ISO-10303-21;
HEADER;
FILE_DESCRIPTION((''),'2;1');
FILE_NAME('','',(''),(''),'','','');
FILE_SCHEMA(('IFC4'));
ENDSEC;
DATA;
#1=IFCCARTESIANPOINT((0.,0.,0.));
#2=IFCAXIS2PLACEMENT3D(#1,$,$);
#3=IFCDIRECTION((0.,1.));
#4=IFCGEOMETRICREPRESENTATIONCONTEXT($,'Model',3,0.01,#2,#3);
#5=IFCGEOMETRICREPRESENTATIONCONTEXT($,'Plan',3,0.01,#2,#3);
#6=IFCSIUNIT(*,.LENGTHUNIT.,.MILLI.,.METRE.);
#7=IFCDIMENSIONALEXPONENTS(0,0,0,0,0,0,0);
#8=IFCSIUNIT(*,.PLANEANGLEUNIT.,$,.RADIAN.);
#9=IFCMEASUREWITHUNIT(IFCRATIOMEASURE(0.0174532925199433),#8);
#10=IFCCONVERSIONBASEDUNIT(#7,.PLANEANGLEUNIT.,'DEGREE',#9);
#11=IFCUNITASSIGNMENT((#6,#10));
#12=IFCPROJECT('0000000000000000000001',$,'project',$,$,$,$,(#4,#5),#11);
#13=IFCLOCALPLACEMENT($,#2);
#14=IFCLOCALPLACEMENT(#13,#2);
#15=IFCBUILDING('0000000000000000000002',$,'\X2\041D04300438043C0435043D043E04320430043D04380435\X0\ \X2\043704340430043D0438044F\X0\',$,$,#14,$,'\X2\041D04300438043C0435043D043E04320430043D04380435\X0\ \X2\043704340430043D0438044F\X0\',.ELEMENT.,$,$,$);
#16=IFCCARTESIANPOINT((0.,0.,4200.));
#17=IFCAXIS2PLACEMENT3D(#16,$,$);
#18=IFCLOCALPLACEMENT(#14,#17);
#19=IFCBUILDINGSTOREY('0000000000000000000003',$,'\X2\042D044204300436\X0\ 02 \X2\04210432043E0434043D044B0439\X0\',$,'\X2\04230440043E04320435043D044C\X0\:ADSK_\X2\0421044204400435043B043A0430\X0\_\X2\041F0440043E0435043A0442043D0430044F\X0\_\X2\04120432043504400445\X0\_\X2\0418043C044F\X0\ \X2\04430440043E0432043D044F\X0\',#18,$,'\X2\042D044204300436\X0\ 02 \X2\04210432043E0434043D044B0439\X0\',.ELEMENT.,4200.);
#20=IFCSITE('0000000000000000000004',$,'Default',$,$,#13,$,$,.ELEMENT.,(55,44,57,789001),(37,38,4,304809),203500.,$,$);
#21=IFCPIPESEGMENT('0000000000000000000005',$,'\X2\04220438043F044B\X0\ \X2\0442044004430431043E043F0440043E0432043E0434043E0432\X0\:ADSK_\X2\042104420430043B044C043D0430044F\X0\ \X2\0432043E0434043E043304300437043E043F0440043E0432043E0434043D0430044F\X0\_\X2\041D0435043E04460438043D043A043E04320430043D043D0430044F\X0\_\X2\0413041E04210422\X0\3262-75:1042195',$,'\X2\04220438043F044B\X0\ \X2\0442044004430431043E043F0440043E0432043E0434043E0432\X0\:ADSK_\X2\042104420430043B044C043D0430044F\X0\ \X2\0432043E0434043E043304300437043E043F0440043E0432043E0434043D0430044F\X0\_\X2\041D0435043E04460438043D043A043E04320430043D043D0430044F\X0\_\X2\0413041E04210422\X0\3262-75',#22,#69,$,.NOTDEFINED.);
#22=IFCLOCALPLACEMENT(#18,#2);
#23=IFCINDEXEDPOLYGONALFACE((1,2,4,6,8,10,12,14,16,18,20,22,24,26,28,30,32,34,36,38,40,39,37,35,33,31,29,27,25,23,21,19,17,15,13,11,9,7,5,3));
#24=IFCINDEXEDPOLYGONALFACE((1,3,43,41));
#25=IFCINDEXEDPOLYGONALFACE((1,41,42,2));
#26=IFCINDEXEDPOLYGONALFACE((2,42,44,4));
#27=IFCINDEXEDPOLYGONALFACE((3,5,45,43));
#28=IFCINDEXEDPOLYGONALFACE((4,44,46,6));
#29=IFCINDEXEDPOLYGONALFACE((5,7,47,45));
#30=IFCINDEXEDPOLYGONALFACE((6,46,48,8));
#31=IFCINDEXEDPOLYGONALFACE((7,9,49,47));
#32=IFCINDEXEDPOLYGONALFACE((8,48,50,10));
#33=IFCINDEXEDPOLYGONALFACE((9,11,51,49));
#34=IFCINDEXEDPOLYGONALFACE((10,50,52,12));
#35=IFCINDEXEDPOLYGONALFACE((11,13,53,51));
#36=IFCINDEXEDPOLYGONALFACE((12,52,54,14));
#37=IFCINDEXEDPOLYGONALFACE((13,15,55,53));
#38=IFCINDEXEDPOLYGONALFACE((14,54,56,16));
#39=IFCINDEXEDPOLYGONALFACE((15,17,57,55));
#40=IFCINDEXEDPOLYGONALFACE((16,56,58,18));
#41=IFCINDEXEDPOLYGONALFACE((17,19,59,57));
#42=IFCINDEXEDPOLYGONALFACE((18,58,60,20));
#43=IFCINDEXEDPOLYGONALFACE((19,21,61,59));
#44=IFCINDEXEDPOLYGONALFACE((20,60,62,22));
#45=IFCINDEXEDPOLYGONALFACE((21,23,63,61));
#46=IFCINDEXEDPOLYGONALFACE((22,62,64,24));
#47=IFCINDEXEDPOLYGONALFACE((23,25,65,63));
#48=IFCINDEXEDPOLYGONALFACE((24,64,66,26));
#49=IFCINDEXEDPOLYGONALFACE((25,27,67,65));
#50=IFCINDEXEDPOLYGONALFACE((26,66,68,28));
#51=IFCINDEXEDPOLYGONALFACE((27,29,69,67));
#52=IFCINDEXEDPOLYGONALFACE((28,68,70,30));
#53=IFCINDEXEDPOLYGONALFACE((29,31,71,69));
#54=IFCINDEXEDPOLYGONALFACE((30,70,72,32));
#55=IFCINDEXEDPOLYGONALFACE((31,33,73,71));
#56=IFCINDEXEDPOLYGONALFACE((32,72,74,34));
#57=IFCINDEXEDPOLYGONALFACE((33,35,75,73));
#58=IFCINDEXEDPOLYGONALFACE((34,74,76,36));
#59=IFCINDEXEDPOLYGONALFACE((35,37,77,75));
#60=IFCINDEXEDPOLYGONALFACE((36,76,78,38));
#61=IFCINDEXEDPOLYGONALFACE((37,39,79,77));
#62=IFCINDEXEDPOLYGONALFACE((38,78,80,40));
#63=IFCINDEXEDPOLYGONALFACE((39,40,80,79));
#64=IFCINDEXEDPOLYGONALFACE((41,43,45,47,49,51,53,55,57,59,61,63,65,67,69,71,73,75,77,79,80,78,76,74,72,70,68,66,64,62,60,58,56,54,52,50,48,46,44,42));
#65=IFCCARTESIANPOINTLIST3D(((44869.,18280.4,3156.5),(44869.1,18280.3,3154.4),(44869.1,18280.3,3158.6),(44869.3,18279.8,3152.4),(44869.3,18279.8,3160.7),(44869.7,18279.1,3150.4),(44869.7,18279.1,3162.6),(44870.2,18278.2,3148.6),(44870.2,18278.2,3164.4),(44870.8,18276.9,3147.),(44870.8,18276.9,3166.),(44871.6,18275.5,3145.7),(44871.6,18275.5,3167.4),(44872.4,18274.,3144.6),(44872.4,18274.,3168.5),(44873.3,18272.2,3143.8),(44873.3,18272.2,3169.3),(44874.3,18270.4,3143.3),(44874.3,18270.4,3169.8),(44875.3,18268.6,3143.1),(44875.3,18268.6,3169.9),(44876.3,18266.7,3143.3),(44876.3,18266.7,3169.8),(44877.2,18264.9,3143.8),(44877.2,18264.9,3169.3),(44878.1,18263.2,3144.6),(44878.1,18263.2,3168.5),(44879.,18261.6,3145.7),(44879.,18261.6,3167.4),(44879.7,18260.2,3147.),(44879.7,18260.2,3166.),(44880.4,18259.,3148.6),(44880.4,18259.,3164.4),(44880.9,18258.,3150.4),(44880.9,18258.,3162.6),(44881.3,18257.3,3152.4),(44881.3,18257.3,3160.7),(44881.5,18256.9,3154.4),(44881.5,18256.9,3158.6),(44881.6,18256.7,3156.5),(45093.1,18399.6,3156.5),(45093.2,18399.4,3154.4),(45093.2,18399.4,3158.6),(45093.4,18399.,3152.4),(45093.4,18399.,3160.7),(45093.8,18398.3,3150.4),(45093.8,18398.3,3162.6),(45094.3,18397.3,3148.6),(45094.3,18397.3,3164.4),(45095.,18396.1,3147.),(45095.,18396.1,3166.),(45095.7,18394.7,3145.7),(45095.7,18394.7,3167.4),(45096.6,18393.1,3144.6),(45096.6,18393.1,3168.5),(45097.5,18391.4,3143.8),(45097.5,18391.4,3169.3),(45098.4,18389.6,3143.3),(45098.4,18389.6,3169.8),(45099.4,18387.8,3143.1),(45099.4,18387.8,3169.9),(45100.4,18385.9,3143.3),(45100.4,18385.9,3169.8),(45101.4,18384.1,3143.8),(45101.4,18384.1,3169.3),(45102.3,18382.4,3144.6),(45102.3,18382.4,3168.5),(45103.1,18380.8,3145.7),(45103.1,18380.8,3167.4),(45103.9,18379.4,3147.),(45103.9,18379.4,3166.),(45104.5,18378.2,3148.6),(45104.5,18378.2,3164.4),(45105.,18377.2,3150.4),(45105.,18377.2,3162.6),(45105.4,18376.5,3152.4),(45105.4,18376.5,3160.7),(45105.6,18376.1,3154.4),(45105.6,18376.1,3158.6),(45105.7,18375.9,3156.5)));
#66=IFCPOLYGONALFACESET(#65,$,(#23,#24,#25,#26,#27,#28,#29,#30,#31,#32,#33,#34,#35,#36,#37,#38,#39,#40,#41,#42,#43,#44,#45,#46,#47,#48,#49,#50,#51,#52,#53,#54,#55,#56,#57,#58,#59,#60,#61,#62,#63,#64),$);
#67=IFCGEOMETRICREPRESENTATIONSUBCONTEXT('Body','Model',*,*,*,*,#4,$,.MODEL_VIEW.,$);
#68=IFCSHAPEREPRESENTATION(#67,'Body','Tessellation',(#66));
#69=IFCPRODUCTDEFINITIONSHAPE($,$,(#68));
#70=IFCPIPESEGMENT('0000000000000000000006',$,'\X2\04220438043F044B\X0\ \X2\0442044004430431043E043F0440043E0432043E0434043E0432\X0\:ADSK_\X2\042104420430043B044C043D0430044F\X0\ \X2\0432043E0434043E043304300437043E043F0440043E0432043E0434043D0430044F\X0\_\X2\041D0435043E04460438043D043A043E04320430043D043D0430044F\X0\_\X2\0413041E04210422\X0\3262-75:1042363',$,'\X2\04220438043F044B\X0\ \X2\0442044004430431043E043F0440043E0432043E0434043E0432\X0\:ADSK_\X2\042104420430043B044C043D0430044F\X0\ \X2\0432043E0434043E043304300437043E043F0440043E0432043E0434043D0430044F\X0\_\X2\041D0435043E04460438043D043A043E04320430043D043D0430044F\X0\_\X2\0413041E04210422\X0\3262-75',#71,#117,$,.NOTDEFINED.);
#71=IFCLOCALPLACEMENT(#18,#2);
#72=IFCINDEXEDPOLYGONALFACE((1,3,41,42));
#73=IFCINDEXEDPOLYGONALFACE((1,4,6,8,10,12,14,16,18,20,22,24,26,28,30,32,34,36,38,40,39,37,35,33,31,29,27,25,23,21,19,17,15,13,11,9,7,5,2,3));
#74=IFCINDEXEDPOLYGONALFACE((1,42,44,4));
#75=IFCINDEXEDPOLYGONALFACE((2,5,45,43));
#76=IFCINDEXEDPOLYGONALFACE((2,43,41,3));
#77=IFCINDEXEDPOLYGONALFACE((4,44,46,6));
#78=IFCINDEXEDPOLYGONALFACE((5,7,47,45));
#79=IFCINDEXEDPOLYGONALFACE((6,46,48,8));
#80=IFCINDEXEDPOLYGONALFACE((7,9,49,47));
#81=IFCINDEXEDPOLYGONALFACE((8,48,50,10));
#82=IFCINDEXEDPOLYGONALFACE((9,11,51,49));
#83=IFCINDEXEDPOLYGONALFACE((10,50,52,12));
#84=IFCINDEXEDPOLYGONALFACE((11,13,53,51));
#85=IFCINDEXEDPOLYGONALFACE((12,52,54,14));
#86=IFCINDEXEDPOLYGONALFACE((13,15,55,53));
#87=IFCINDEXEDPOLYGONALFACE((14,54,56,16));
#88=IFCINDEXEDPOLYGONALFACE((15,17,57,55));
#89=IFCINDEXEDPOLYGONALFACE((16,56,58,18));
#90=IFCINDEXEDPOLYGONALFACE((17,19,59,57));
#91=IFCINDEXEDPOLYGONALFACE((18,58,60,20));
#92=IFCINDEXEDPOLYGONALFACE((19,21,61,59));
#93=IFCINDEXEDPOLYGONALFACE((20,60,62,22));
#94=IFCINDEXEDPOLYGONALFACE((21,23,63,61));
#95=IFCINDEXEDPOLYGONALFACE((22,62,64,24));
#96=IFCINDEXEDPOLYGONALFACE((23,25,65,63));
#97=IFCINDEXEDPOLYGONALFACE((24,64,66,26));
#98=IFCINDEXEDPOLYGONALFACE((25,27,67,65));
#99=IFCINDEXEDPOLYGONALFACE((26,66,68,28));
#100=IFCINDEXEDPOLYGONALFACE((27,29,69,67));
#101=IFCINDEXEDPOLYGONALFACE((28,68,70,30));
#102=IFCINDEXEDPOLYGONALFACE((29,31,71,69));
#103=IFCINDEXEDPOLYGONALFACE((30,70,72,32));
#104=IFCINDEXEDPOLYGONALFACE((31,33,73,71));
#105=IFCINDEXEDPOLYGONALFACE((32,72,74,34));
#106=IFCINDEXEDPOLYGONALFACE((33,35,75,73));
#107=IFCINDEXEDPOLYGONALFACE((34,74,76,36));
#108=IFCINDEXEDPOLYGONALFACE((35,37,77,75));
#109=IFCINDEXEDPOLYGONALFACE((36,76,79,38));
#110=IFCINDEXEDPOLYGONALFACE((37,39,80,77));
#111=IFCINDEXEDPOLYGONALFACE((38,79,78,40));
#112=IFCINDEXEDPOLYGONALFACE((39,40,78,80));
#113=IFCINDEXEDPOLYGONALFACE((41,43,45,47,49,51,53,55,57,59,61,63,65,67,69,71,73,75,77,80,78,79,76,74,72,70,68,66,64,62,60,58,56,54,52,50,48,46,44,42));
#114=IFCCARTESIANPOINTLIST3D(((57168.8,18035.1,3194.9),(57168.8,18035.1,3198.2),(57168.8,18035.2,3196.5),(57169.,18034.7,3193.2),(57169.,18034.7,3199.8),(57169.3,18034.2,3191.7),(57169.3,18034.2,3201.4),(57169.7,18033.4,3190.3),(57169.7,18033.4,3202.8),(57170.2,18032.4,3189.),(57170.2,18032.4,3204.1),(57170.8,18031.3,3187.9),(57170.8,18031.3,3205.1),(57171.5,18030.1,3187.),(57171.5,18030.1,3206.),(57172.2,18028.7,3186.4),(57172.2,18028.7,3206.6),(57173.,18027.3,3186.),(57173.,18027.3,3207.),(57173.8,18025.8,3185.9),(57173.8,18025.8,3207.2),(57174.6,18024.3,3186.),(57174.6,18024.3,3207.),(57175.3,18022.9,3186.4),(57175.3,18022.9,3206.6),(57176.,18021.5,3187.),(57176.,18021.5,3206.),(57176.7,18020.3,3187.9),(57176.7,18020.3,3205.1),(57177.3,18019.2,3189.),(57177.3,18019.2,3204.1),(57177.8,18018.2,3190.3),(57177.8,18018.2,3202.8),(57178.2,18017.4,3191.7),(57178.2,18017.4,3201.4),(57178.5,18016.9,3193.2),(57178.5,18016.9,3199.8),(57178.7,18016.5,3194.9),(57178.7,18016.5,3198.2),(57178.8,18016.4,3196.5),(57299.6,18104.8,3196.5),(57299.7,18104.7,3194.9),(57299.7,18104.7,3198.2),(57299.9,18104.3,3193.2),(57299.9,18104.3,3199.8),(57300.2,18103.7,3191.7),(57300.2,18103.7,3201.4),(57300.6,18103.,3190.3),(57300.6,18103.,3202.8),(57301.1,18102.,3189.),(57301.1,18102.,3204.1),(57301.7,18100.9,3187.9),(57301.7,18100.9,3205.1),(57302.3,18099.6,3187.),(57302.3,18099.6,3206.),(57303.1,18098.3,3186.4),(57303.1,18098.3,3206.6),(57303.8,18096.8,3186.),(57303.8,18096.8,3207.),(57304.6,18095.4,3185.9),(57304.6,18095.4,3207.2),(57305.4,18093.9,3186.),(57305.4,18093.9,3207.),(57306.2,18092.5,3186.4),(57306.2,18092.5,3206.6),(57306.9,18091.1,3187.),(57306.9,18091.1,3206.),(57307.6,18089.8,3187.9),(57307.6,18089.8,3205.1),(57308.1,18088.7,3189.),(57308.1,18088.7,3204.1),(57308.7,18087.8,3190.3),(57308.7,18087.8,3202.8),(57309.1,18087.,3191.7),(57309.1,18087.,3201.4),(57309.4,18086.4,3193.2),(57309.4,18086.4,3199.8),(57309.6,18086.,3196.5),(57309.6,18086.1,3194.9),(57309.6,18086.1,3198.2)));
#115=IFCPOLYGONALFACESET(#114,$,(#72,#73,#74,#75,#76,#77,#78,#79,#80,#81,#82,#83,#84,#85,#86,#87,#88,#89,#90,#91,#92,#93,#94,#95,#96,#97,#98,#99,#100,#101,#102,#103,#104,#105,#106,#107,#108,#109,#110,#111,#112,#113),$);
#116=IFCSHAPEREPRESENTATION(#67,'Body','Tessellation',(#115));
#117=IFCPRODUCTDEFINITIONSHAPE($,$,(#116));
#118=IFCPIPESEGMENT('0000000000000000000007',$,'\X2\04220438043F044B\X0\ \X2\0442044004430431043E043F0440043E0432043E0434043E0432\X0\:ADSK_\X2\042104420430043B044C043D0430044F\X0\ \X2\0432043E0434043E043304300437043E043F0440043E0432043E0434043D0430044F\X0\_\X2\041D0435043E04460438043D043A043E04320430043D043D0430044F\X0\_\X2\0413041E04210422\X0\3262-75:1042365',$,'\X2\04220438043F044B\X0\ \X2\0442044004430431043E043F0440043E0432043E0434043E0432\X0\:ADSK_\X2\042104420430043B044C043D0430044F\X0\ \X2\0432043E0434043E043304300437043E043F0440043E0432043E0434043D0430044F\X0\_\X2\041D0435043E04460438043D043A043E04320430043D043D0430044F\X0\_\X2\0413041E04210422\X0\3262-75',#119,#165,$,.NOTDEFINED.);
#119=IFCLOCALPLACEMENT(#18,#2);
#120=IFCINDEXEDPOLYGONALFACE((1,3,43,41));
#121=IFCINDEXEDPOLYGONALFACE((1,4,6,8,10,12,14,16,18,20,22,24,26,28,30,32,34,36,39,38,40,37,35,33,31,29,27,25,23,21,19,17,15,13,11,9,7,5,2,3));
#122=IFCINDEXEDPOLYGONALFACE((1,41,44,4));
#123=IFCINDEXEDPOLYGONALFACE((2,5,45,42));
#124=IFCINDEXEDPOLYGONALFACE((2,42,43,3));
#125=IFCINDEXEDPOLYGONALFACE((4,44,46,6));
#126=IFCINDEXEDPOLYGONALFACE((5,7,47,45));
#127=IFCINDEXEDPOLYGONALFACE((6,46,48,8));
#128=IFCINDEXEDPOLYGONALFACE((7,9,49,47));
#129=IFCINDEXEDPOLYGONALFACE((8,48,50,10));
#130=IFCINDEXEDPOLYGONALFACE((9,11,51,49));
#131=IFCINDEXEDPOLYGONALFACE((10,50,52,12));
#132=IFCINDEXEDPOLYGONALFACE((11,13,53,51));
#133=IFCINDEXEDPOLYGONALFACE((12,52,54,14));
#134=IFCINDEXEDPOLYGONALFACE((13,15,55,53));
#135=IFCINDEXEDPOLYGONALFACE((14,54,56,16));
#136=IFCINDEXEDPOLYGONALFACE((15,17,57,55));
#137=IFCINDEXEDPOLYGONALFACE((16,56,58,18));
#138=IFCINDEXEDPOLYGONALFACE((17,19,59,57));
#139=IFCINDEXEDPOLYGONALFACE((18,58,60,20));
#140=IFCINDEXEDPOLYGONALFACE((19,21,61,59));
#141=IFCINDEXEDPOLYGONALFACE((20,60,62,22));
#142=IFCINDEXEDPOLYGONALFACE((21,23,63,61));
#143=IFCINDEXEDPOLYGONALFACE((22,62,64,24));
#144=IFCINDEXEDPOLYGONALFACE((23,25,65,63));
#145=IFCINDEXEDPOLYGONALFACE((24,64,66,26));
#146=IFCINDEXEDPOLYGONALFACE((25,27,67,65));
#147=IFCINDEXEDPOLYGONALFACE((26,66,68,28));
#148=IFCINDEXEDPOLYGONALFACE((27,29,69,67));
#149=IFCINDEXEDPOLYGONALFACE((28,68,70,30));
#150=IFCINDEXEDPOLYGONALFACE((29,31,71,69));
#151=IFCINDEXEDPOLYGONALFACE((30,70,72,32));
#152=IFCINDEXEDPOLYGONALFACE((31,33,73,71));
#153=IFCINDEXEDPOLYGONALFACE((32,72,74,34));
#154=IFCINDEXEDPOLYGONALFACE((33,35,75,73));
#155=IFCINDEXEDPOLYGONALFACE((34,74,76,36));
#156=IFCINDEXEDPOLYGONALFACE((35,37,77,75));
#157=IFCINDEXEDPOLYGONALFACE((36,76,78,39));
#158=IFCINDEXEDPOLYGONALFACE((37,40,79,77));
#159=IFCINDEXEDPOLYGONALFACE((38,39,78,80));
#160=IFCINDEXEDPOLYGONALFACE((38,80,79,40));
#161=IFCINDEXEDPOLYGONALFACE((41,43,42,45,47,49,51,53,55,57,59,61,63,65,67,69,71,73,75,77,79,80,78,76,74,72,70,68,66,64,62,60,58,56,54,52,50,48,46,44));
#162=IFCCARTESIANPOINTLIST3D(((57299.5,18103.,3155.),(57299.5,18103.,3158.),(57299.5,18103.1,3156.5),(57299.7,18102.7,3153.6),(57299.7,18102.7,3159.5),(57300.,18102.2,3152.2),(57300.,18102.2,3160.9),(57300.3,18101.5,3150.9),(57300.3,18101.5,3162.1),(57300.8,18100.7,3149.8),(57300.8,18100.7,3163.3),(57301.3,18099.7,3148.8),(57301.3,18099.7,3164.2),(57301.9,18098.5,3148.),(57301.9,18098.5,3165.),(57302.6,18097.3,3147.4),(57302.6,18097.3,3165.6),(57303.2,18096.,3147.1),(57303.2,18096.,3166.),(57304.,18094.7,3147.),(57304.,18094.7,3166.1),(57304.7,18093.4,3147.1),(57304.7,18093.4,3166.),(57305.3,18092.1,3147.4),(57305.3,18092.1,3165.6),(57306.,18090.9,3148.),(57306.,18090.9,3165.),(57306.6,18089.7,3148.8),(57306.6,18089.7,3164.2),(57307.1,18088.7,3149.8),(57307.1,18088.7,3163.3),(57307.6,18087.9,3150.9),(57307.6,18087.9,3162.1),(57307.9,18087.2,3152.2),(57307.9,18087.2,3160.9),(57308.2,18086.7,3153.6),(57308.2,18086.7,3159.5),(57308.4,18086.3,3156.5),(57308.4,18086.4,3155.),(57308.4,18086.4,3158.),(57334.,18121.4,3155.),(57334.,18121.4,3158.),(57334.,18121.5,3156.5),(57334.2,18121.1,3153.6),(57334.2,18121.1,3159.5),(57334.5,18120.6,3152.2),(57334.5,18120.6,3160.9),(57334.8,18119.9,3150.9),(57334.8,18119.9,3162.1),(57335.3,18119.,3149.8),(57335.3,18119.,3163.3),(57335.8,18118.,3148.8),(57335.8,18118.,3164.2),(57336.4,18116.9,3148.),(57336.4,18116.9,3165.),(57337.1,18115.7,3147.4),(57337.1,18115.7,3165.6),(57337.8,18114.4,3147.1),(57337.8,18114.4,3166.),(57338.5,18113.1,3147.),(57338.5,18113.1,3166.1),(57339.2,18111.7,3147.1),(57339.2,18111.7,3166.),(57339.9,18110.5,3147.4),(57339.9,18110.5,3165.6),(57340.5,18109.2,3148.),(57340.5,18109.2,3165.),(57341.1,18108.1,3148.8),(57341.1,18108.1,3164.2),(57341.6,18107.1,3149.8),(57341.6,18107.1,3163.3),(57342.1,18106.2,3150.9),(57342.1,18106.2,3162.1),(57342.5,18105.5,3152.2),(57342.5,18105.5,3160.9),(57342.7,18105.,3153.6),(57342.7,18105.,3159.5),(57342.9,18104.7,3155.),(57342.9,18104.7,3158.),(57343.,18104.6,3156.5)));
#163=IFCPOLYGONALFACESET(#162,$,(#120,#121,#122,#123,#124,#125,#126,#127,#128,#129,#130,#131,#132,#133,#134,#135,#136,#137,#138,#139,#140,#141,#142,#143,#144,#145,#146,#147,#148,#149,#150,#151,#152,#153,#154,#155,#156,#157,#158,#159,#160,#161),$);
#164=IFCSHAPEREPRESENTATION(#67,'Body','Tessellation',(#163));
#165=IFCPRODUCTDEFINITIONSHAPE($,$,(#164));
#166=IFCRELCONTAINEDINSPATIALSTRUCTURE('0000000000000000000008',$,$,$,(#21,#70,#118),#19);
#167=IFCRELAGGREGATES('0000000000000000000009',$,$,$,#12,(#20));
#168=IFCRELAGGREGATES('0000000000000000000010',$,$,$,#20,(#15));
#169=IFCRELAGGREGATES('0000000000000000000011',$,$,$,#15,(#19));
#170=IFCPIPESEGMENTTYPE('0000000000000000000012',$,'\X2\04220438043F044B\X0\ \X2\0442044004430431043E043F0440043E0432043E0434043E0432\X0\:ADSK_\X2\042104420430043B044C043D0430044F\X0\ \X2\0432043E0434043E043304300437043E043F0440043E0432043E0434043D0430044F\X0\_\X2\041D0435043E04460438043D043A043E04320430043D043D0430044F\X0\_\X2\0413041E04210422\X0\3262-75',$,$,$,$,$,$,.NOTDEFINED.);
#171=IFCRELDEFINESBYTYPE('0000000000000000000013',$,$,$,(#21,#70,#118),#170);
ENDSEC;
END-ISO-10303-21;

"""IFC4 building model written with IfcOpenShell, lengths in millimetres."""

from ifc_helpers import new_model, entity, si_unit, converted_unit, direction, frame, origin, place, context, subcontext, project, spatial, indexed_curve, outline, extrude, type_object, element, save


model = new_model("IFC4")

# Units and contexts
model_context = context("Model", 3, precision=0.01, world=origin(), true_north=direction((0.0, 1.0)))
plan_context = context("Plan", 3, precision=0.01, world=origin(), true_north=direction((0.0, 1.0)))
body_context = subcontext(model_context, "Body", "Model", "MODEL_VIEW")
ifc_project = project(units=[si_unit("LENGTHUNIT", "METRE", prefix="MILLI"), converted_unit("PLANEANGLEUNIT", "DEGREE", entity("IfcRatioMeasure", 0.0174532925199433), si_unit("PLANEANGLEUNIT", "RADIAN"), dimensions=[0, 0, 0, 0, 0, 0, 0])], contexts=[model_context, plan_context])

# Site, building, storey
site_placement = place(None, origin())
site = spatial("IfcSite", under=ifc_project, at=site_placement, Name="Default", CompositionType="ELEMENT", RefLatitude=(55, 44, 57, 789001), RefLongitude=(37, 38, 4, 304809), RefElevation=203500.0)
building_placement = place(site_placement, origin())
building = spatial("IfcBuilding", under=site, at=building_placement, Name="Наименование здания", LongName="Наименование здания", CompositionType="ELEMENT")
storey_placement = place(building_placement, frame((0.0, 0.0, 4200.0)))
storey = spatial("IfcBuildingStorey", under=building, at=storey_placement, Name="Этаж 02 Сводный", ObjectType="Уровень:ADSK_Стрелка_Проектная_Вверх_Имя уровня", LongName="Этаж 02 Сводный", CompositionType="ELEMENT", Elevation=4200.0)

# Pipe segments
pipe_segment_type = type_object("IfcPipeSegmentType", Name="Типы трубопроводов:ADSK_Стальная водогазопроводная_Неоцинкованная_ГОСТ3262-75", PredefinedType="NOTDEFINED")
placement = place(storey_placement, origin())
element("IfcPipeSegment", 1, at=placement, inside=storey, type_object=pipe_segment_type, Name="Типы трубопроводов:ADSK_Стальная водогазопроводная_Неоцинкованная_ГОСТ3262-75:1042195", ObjectType="Типы трубопроводов:ADSK_Стальная водогазопроводная_Неоцинкованная_ГОСТ3262-75", PredefinedType="NOTDEFINED", context=body_context, shape_type="SweptSolid", body=[
    extrude(outline(indexed_curve([(13.4, 0.0), (13.2, 2.1), (12.7, 4.1), (11.9, 6.1), (10.8, 7.9), (9.5, 9.5), (7.9, 10.8), (6.1, 11.9), (4.1, 12.7), (2.1, 13.2), (0.0, 13.4), (-2.1, 13.2), (-4.1, 12.7), (-6.1, 11.9), (-7.9, 10.8), (-9.5, 9.5), (-10.8, 7.9), (-11.9, 6.1), (-12.7, 4.1), (-13.2, 2.1), (-13.4, 0.0), (-13.2, -2.1), (-12.7, -4.1), (-11.9, -6.1), (-10.8, -7.9), (-9.5, -9.5), (-7.9, -10.8), (-6.1, -11.9), (-4.1, -12.7), (-2.1, -13.2), (0.0, -13.4), (2.1, -13.2), (4.1, -12.7), (6.1, -11.9), (7.9, -10.8), (9.5, -9.5), (10.8, -7.9), (11.9, -6.1), (12.7, -4.1), (13.2, -2.1), (13.4, 0.0)], self_intersect=False)), frame((44875.3, 18268.6, 3156.5), z_axis=(0.882948, 0.469472, 0.0), x_axis=(0.469472, -0.882948, 0.0)), (0.0, 0.0, 1.0), 253.8),
])
element("IfcPipeSegment", 2, at=placement, inside=storey, type_object=pipe_segment_type, Name="Типы трубопроводов:ADSK_Стальная водогазопроводная_Неоцинкованная_ГОСТ3262-75:1042363", ObjectType="Типы трубопроводов:ADSK_Стальная водогазопроводная_Неоцинкованная_ГОСТ3262-75", PredefinedType="NOTDEFINED", context=body_context, shape_type="SweptSolid", body=[
    extrude(outline(indexed_curve([(10.6, 0.0), (10.5, 1.7), (10.1, 3.3), (9.5, 4.8), (8.6, 6.3), (7.5, 7.5), (6.3, 8.6), (4.8, 9.5), (3.3, 10.1), (1.7, 10.5), (0.0, 10.6), (-1.7, 10.5), (-3.3, 10.1), (-4.8, 9.5), (-6.3, 8.6), (-7.5, 7.5), (-8.6, 6.3), (-9.5, 4.8), (-10.1, 3.3), (-10.5, 1.7), (-10.6, 0.0), (-10.5, -1.7), (-10.1, -3.3), (-9.5, -4.8), (-8.6, -6.3), (-7.5, -7.5), (-6.3, -8.6), (-4.8, -9.5), (-3.3, -10.1), (-1.7, -10.5), (0.0, -10.6), (1.7, -10.5), (3.3, -10.1), (4.8, -9.5), (6.3, -8.6), (7.5, -7.5), (8.6, -6.3), (9.5, -4.8), (10.1, -3.3), (10.5, -1.7), (10.6, 0.0)], self_intersect=False)), frame((57173.8, 18025.8, 3196.5), z_axis=(0.882948, 0.469472, 0.0), x_axis=(-0.469472, 0.882948, 0.0)), (0.0, 0.0, 1.0), 148.2),
])
element("IfcPipeSegment", 3, at=placement, inside=storey, type_object=pipe_segment_type, Name="Типы трубопроводов:ADSK_Стальная водогазопроводная_Неоцинкованная_ГОСТ3262-75:1042365", ObjectType="Типы трубопроводов:ADSK_Стальная водогазопроводная_Неоцинкованная_ГОСТ3262-75", PredefinedType="NOTDEFINED", context=body_context, shape_type="SweptSolid", body=[
    extrude(outline(indexed_curve([(9.6, 0.0), (9.4, 1.5), (9.1, 3.0), (8.5, 4.3), (7.7, 5.6), (6.8, 6.8), (5.6, 7.7), (4.3, 8.5), (3.0, 9.1), (1.5, 9.4), (0.0, 9.6), (-1.5, 9.4), (-3.0, 9.1), (-4.3, 8.5), (-5.6, 7.7), (-6.8, 6.8), (-7.7, 5.6), (-8.5, 4.3), (-9.1, 3.0), (-9.4, 1.5), (-9.6, 0.0), (-9.4, -1.5), (-9.1, -3.0), (-8.5, -4.3), (-7.7, -5.6), (-6.8, -6.8), (-5.6, -7.7), (-4.3, -8.5), (-3.0, -9.1), (-1.5, -9.4), (0.0, -9.6), (1.5, -9.4), (3.0, -9.1), (4.3, -8.5), (5.6, -7.7), (6.8, -6.8), (7.7, -5.6), (8.5, -4.3), (9.1, -3.0), (9.4, -1.5), (9.6, 0.0)], self_intersect=False)), frame((57303.9, 18094.7, 3156.5), z_axis=(0.882948, 0.469472, 0.0), x_axis=(-0.469472, 0.882948, 0.0)), (0.0, 0.0, 1.0), 39.1),
])

save(model, "model.ifc")
